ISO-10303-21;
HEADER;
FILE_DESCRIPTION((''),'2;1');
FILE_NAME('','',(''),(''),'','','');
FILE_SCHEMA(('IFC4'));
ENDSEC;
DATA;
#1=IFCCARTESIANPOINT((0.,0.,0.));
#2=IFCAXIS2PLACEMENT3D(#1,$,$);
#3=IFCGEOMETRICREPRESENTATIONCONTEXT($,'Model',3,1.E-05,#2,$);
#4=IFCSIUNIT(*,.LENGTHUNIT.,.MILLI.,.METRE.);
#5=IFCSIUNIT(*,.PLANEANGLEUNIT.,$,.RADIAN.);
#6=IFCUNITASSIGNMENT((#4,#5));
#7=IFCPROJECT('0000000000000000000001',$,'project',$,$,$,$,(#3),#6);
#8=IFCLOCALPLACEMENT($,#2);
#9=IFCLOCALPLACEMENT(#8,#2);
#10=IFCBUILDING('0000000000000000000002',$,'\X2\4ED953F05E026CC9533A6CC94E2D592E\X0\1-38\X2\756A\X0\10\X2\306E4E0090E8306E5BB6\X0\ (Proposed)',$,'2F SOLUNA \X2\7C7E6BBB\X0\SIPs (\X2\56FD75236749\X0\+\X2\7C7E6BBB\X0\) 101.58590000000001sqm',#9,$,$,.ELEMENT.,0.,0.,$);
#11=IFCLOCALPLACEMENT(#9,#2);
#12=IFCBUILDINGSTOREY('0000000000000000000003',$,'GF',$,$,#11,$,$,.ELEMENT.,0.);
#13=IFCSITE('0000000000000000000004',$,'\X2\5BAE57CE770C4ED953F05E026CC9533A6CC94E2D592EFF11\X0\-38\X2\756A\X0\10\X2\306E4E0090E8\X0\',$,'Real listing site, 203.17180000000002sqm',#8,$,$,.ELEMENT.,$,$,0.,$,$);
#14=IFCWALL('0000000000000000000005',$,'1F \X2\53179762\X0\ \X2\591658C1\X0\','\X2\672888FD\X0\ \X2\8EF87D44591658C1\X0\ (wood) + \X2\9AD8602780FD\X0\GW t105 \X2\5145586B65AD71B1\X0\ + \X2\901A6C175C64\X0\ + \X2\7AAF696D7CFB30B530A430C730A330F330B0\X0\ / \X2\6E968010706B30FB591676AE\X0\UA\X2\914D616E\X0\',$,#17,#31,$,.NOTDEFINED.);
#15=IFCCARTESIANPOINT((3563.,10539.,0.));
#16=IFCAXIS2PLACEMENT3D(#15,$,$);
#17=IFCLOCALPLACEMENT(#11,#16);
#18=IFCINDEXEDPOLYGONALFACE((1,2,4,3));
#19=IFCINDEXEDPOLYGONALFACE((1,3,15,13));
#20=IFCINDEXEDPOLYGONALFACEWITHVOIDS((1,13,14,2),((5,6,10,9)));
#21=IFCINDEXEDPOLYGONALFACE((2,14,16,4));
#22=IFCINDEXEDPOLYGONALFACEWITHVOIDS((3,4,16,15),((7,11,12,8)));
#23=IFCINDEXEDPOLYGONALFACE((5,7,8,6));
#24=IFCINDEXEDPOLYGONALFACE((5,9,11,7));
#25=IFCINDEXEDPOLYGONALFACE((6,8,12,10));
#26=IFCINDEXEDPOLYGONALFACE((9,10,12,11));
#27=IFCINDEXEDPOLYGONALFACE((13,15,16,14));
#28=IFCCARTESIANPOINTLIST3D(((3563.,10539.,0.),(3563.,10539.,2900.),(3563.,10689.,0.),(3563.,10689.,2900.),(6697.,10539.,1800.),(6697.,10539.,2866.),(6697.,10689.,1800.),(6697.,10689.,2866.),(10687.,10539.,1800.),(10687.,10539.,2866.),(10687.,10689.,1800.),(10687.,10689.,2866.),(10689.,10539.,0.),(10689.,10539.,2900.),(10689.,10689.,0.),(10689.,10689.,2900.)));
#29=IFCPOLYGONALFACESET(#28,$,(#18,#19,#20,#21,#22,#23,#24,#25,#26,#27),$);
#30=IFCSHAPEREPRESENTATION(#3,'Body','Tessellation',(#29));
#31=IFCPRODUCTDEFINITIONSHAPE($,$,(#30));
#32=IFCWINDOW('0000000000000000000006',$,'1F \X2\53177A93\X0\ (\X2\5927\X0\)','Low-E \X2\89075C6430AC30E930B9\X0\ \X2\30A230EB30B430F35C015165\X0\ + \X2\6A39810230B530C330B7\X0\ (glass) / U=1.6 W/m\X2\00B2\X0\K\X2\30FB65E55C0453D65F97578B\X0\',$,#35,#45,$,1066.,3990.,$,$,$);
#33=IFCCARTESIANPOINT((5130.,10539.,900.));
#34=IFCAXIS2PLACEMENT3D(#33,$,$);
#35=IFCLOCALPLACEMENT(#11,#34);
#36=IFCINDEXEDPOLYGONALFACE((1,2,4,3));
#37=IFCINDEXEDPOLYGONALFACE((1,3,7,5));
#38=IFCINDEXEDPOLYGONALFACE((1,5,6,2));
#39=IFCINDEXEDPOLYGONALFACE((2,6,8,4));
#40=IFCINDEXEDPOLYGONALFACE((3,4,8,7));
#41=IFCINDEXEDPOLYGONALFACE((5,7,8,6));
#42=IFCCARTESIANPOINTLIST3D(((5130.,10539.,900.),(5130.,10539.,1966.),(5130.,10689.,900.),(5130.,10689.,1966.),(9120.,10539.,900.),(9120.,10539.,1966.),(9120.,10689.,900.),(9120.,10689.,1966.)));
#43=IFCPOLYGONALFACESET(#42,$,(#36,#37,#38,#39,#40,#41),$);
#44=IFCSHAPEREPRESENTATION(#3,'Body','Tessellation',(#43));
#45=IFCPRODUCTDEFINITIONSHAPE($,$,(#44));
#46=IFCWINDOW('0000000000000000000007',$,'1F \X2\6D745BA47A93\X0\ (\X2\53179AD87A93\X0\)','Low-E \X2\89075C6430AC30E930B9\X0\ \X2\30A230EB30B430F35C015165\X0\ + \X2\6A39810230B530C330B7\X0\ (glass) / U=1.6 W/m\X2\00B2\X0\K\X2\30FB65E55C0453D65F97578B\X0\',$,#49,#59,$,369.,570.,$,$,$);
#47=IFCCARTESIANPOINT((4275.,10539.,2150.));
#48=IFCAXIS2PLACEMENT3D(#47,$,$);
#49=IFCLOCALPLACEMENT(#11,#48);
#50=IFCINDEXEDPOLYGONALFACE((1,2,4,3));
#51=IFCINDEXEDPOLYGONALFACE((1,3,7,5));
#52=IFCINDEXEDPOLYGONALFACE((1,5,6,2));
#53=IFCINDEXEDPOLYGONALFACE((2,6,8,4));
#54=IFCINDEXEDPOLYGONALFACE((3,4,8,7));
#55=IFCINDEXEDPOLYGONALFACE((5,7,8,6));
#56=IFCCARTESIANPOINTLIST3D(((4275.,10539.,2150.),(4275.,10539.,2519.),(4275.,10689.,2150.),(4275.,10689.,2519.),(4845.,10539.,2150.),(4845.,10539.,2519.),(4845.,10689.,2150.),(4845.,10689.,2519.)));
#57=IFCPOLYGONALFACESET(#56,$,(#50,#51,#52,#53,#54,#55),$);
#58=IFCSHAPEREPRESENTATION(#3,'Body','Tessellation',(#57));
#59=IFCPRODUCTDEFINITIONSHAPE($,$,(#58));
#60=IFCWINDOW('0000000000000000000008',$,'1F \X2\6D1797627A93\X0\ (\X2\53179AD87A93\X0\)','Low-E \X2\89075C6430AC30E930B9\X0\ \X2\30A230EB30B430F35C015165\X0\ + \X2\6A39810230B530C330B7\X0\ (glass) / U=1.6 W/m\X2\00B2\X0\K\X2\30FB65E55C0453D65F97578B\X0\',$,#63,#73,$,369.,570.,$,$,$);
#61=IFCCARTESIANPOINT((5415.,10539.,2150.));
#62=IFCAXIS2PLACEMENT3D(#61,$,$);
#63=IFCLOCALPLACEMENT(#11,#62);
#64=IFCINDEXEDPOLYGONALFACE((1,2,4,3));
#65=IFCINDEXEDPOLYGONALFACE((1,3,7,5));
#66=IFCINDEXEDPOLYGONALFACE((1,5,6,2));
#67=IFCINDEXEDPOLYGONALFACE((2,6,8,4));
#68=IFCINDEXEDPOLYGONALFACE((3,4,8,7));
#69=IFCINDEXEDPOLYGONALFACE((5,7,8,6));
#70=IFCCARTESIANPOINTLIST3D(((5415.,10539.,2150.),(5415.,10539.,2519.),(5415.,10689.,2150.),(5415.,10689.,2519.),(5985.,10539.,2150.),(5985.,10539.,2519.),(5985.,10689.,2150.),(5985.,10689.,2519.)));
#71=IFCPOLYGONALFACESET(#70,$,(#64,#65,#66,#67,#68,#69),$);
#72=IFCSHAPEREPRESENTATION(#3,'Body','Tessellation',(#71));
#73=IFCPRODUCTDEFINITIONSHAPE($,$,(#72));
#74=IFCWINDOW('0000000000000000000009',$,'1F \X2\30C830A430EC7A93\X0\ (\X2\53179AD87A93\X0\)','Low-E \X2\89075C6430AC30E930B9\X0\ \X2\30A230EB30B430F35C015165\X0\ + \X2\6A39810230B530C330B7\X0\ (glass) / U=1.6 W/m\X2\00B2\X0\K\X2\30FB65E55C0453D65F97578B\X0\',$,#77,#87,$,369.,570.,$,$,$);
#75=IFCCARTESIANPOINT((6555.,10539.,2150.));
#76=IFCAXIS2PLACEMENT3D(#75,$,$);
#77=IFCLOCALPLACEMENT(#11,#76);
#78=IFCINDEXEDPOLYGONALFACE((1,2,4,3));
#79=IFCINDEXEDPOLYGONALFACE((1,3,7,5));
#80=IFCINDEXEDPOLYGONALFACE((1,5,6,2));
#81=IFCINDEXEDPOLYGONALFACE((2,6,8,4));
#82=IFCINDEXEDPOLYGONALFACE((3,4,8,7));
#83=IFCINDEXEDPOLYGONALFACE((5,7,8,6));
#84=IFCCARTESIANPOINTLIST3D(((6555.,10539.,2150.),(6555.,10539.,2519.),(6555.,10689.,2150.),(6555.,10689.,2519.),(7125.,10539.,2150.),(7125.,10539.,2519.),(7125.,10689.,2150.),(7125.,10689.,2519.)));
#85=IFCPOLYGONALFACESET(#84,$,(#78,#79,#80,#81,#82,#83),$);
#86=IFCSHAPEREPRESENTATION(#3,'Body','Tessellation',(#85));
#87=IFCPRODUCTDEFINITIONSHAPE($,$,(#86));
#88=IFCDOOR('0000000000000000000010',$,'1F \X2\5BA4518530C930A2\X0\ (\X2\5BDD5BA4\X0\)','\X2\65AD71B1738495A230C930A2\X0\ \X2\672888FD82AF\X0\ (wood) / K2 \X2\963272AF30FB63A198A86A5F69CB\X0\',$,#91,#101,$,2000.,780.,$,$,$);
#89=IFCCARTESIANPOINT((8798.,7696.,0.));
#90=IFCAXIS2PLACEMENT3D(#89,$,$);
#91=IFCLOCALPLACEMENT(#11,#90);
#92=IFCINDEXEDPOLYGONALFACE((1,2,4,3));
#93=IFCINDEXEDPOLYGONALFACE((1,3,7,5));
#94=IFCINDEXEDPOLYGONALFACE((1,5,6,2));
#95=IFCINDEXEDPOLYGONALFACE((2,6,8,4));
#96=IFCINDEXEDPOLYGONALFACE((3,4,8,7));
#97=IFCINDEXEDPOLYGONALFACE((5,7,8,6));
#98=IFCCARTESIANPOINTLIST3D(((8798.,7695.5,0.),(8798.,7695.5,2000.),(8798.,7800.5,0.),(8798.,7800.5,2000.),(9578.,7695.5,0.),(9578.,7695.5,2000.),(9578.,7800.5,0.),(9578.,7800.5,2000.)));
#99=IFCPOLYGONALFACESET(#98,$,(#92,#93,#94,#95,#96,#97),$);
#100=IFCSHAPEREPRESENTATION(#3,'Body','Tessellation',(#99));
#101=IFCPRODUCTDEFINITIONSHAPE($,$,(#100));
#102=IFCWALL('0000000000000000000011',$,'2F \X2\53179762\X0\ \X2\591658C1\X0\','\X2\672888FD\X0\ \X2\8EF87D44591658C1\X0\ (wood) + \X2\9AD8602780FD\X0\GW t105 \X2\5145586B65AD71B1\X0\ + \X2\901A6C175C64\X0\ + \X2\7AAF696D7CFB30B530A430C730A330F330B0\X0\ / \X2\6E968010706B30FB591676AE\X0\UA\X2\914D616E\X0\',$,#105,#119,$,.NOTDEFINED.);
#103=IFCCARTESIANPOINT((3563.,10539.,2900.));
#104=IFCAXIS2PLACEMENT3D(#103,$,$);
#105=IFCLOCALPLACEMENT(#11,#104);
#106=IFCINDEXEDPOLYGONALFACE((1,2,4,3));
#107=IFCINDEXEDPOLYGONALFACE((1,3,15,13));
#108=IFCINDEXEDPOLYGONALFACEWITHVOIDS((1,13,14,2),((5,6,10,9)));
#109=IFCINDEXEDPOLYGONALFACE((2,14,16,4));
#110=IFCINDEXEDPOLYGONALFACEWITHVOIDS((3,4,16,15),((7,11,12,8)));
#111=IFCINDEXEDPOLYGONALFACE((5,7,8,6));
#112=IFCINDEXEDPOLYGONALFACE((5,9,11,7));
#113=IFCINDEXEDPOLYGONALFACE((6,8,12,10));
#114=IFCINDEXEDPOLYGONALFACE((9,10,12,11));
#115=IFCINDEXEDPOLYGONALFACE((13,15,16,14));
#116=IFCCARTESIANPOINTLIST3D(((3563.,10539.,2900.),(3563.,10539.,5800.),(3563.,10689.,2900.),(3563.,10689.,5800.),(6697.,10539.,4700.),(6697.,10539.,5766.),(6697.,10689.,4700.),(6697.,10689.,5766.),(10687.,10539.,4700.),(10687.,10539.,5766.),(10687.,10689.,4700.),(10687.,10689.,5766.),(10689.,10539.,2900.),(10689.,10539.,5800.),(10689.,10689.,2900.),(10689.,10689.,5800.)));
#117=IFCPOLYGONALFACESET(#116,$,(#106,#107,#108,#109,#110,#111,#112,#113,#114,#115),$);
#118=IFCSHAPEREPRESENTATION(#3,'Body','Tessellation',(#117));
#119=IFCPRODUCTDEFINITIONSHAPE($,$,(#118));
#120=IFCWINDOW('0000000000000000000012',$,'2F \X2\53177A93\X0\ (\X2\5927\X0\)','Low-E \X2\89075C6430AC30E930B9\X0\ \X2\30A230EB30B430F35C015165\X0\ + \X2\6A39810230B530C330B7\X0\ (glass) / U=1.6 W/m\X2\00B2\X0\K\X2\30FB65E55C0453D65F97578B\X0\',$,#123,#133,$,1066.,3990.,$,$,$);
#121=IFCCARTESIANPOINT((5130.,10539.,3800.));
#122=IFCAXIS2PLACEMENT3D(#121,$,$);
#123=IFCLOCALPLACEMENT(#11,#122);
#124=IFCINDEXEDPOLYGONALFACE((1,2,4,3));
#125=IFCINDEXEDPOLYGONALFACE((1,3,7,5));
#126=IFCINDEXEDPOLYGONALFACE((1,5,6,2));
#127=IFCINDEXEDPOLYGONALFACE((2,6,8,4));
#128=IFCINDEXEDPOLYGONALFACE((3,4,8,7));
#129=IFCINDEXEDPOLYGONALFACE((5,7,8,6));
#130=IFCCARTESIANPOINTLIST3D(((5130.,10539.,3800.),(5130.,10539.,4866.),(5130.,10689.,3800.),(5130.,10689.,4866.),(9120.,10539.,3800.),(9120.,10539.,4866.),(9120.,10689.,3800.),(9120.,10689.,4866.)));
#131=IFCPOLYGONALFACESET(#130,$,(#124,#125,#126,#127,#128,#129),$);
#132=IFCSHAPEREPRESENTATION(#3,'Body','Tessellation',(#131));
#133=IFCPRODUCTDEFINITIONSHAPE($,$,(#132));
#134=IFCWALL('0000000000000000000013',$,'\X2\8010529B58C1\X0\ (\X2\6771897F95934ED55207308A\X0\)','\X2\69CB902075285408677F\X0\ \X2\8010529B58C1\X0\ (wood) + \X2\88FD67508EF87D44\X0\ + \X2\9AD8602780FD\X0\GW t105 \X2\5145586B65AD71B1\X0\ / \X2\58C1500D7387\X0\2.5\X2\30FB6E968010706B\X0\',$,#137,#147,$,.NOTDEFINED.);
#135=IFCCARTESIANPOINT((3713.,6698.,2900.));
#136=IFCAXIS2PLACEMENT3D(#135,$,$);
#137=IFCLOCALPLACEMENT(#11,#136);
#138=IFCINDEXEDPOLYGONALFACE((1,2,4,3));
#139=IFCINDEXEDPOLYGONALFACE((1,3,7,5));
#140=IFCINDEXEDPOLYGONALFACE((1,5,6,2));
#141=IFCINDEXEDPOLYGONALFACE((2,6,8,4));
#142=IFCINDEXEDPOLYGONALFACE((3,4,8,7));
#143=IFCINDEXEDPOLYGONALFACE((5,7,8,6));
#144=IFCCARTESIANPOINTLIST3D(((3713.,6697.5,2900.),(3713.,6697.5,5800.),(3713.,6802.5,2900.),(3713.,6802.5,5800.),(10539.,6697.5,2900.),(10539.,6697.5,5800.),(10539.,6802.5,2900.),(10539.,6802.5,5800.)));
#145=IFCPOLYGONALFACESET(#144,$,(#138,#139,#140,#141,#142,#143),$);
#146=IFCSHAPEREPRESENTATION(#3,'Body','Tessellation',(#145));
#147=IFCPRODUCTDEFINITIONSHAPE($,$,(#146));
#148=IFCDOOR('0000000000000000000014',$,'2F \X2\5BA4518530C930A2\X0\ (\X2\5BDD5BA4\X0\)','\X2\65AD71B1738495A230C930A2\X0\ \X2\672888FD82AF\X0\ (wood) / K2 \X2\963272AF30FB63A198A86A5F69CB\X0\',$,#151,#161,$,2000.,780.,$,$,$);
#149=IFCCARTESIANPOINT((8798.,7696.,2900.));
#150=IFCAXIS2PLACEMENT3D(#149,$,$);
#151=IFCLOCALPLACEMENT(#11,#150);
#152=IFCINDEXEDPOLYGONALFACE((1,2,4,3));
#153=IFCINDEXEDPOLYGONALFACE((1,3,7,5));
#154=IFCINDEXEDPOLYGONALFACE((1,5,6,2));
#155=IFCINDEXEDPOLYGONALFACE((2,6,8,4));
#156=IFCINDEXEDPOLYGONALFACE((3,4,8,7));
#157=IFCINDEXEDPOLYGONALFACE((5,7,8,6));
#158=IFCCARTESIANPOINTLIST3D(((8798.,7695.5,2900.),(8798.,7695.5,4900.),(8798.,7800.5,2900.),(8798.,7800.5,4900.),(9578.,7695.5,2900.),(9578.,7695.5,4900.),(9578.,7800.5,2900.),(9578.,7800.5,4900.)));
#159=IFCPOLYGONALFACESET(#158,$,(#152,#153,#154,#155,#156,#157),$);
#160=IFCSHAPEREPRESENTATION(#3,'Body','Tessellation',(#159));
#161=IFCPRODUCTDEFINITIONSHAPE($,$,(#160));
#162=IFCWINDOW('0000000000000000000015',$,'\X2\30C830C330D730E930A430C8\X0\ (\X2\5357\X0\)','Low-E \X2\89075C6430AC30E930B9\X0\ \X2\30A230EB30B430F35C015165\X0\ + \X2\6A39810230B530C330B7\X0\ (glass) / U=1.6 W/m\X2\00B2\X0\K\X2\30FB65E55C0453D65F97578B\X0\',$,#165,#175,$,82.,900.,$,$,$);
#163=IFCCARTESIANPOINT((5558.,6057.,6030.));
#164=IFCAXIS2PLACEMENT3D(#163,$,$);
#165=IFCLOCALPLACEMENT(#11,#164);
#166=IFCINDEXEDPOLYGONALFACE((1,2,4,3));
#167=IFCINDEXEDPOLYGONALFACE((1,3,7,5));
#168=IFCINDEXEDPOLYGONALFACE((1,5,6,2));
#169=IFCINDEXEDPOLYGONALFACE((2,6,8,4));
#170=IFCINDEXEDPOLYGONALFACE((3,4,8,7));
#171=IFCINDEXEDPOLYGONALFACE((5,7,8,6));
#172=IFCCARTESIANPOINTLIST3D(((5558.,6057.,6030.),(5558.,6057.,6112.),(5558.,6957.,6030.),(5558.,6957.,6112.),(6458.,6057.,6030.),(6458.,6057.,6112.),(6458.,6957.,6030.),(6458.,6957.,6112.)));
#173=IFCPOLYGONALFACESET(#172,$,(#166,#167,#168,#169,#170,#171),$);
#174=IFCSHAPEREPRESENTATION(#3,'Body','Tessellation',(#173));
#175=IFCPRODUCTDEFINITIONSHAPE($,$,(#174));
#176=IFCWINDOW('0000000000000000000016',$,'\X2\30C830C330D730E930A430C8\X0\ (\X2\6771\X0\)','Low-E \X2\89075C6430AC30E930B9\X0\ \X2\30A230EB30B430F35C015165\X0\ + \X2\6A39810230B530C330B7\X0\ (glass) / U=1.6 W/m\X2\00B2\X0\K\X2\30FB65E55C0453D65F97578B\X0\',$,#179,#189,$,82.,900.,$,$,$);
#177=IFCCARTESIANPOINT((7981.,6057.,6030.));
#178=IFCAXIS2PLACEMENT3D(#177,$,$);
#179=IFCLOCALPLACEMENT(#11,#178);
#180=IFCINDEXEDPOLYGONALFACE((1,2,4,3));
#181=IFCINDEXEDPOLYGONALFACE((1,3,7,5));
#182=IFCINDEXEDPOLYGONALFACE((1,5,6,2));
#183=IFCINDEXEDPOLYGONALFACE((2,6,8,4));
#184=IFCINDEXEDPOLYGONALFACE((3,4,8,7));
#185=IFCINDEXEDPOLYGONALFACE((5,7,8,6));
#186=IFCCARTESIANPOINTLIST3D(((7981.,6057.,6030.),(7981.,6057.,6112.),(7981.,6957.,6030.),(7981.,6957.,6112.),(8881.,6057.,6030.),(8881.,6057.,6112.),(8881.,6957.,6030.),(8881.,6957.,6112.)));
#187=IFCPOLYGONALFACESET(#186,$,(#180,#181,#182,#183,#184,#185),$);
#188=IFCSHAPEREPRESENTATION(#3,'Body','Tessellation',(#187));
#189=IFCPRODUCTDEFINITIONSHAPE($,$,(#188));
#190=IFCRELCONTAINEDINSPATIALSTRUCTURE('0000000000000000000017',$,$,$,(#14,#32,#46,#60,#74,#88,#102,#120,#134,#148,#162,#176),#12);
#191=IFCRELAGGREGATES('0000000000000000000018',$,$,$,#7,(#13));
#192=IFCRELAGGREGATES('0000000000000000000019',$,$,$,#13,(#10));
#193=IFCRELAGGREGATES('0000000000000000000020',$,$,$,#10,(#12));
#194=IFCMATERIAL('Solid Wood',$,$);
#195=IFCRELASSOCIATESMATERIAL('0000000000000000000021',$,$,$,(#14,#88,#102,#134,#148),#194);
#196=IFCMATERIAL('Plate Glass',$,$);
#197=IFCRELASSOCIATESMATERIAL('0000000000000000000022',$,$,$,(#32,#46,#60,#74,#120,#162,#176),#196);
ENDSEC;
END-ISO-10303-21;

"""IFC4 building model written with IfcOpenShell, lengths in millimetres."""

from ifc_helpers import new_model, si_unit, frame, frame_2d, origin, place, context, project, spatial, rectangle, extrude, material, element, fill, save


model = new_model("IFC4")

# Units and contexts
model_context = context("Model", 3, precision=1e-05, world=origin())
ifc_project = project(units=[si_unit("LENGTHUNIT", "METRE", prefix="MILLI"), si_unit("PLANEANGLEUNIT", "RADIAN")], contexts=[model_context])

# Site, building, storey
site_placement = place(None, origin())
site = spatial("IfcSite", under=ifc_project, at=site_placement, Name="宮城県仙台市泉区泉中央１-38番10の一部", ObjectType="Real listing site, 203.17180000000002sqm", CompositionType="ELEMENT", RefElevation=0.0)
building_placement = place(site_placement, origin())
building = spatial("IfcBuilding", under=site, at=building_placement, Name="仙台市泉区泉中央1-38番10の一部の家 (Proposed)", ObjectType="2F SOLUNA 籾殻SIPs (国産杉+籾殻) 101.58590000000001sqm", CompositionType="ELEMENT", ElevationOfRefHeight=0.0, ElevationOfTerrain=0.0)
storey_placement = place(building_placement, origin())
storey = spatial("IfcBuildingStorey", under=building, at=storey_placement, Name="GF", CompositionType="ELEMENT", Elevation=0.0)

# Wall, openings, windows
ifc_material_1 = material(Name="Solid Wood")
wall_1_placement = place(storey_placement, frame((3563.0, 10539.0, 0.0)))
wall_1 = element("IfcWall", 1, at=wall_1_placement, inside=storey, material=ifc_material_1, Name="1F 北面 外壁", Description="木製 軸組外壁 (wood) + 高性能GW t105 充填断熱 + 通気層 + 窯業系サイディング / 準耐火・外皮UA配慮", PredefinedType="NOTDEFINED", context=model_context, shape_type="SweptSolid", body=[
    extrude(rectangle(XDim=7126.0, YDim=150.0, at=frame_2d((3563.0, 75.0))), frame((3563.0, 10539.0, 0.0)), (0.0, 0.0, 1.0), 2900.0),
])
opening_1_placement = place(storey_placement, frame((5130.0, 10539.0, 900.0)))
opening_1 = element("IfcOpeningElement", 2, at=opening_1_placement, cuts=wall_1, PredefinedType="NOTDEFINED", context=model_context, shape_type="SweptSolid", body=[
    extrude(rectangle(XDim=3990.0, YDim=150.0, at=frame_2d((1995.0, 75.0))), frame((5130.0, 10539.0, 900.0)), (0.0, 0.0, 1.0), 1066.0),
])
opening_2_placement = place(storey_placement, frame((4275.0, 10539.0, 2150.0)))
opening_2 = element("IfcOpeningElement", 3, at=opening_2_placement, cuts=wall_1, PredefinedType="NOTDEFINED", context=model_context, shape_type="SweptSolid", body=[
    extrude(rectangle(XDim=570.0, YDim=150.0, at=frame_2d((285.0, 75.0))), frame((4275.0, 10539.0, 2150.0)), (0.0, 0.0, 1.0), 369.0),
])
opening_3_placement = place(storey_placement, frame((5415.0, 10539.0, 2150.0)))
opening_3 = element("IfcOpeningElement", 4, at=opening_3_placement, cuts=wall_1, PredefinedType="NOTDEFINED", context=model_context, shape_type="SweptSolid", body=[
    extrude(rectangle(XDim=570.0, YDim=150.0, at=frame_2d((285.0, 75.0))), frame((5415.0, 10539.0, 2150.0)), (0.0, 0.0, 1.0), 369.0),
])
opening_4_placement = place(storey_placement, frame((6555.0, 10539.0, 2150.0)))
opening_4 = element("IfcOpeningElement", 5, at=opening_4_placement, cuts=wall_1, PredefinedType="NOTDEFINED", context=model_context, shape_type="SweptSolid", body=[
    extrude(rectangle(XDim=570.0, YDim=150.0, at=frame_2d((285.0, 75.0))), frame((6555.0, 10539.0, 2150.0)), (0.0, 0.0, 1.0), 369.0),
])
ifc_material_2 = material(Name="Plate Glass")
window_1_placement = place(storey_placement, frame((5130.0, 10539.0, 900.0)))
window_1 = element("IfcWindow", 6, at=window_1_placement, inside=storey, material=ifc_material_2, Name="1F 北窓 (大)", Description="Low-E 複層ガラス アルゴン封入 + 樹脂サッシ (glass) / U=1.6 W/m²K・日射取得型", OverallHeight=1066.0, OverallWidth=3990.0, context=model_context, shape_type="SweptSolid", body=[
    extrude(rectangle(XDim=3990.0, YDim=150.0, at=frame_2d((1995.0, 75.0))), frame((5130.0, 10539.0, 900.0)), (0.0, 0.0, 1.0), 1066.0),
])
fill(opening_1, window_1)
window_2_placement = place(storey_placement, frame((4275.0, 10539.0, 2150.0)))
window_2 = element("IfcWindow", 7, at=window_2_placement, inside=storey, material=ifc_material_2, Name="1F 浴室窓 (北高窓)", Description="Low-E 複層ガラス アルゴン封入 + 樹脂サッシ (glass) / U=1.6 W/m²K・日射取得型", OverallHeight=369.0, OverallWidth=570.0, context=model_context, shape_type="SweptSolid", body=[
    extrude(rectangle(XDim=570.0, YDim=150.0, at=frame_2d((285.0, 75.0))), frame((4275.0, 10539.0, 2150.0)), (0.0, 0.0, 1.0), 369.0),
])
fill(opening_2, window_2)
window_3_placement = place(storey_placement, frame((5415.0, 10539.0, 2150.0)))
window_3 = element("IfcWindow", 8, at=window_3_placement, inside=storey, material=ifc_material_2, Name="1F 洗面窓 (北高窓)", Description="Low-E 複層ガラス アルゴン封入 + 樹脂サッシ (glass) / U=1.6 W/m²K・日射取得型", OverallHeight=369.0, OverallWidth=570.0, context=model_context, shape_type="SweptSolid", body=[
    extrude(rectangle(XDim=570.0, YDim=150.0, at=frame_2d((285.0, 75.0))), frame((5415.0, 10539.0, 2150.0)), (0.0, 0.0, 1.0), 369.0),
])
fill(opening_3, window_3)
window_4_placement = place(storey_placement, frame((6555.0, 10539.0, 2150.0)))
window_4 = element("IfcWindow", 9, at=window_4_placement, inside=storey, material=ifc_material_2, Name="1F トイレ窓 (北高窓)", Description="Low-E 複層ガラス アルゴン封入 + 樹脂サッシ (glass) / U=1.6 W/m²K・日射取得型", OverallHeight=369.0, OverallWidth=570.0, context=model_context, shape_type="SweptSolid", body=[
    extrude(rectangle(XDim=570.0, YDim=150.0, at=frame_2d((285.0, 75.0))), frame((6555.0, 10539.0, 2150.0)), (0.0, 0.0, 1.0), 369.0),
])
fill(opening_4, window_4)

# Door
door_1_placement = place(storey_placement, frame((8798.0, 7696.0, 0.0)))
element("IfcDoor", 10, at=door_1_placement, inside=storey, material=ifc_material_1, Name="1F 室内ドア (寝室)", Description="断熱玄関ドア 木製芯 (wood) / K2 防犯・採風機構", OverallHeight=2000.0, OverallWidth=780.0, context=model_context, shape_type="SweptSolid", body=[
    extrude(rectangle(XDim=780.0, YDim=105.0, at=frame_2d((390.0, 52.0))), frame((8798.0, 7696.0, 0.0)), (0.0, 0.0, 1.0), 2000.0),
])

# Wall, opening, window
wall_2_placement = place(storey_placement, frame((3563.0, 10539.0, 2900.0)))
wall_2 = element("IfcWall", 11, at=wall_2_placement, inside=storey, material=ifc_material_1, Name="2F 北面 外壁", Description="木製 軸組外壁 (wood) + 高性能GW t105 充填断熱 + 通気層 + 窯業系サイディング / 準耐火・外皮UA配慮", PredefinedType="NOTDEFINED", context=model_context, shape_type="SweptSolid", body=[
    extrude(rectangle(XDim=7126.0, YDim=150.0, at=frame_2d((3563.0, 75.0))), frame((3563.0, 10539.0, 2900.0)), (0.0, 0.0, 1.0), 2900.0),
])
opening_5_placement = place(storey_placement, frame((5130.0, 10539.0, 3800.0)))
opening_5 = element("IfcOpeningElement", 12, at=opening_5_placement, cuts=wall_2, PredefinedType="NOTDEFINED", context=model_context, shape_type="SweptSolid", body=[
    extrude(rectangle(XDim=3990.0, YDim=150.0, at=frame_2d((1995.0, 75.0))), frame((5130.0, 10539.0, 3800.0)), (0.0, 0.0, 1.0), 1066.0),
])
window_5_placement = place(storey_placement, frame((5130.0, 10539.0, 3800.0)))
window_5 = element("IfcWindow", 13, at=window_5_placement, inside=storey, material=ifc_material_2, Name="2F 北窓 (大)", Description="Low-E 複層ガラス アルゴン封入 + 樹脂サッシ (glass) / U=1.6 W/m²K・日射取得型", OverallHeight=1066.0, OverallWidth=3990.0, context=model_context, shape_type="SweptSolid", body=[
    extrude(rectangle(XDim=3990.0, YDim=150.0, at=frame_2d((1995.0, 75.0))), frame((5130.0, 10539.0, 3800.0)), (0.0, 0.0, 1.0), 1066.0),
])
fill(opening_5, window_5)

# Wall
wall_3_placement = place(storey_placement, frame((3713.0, 6698.0, 2900.0)))
element("IfcWall", 14, at=wall_3_placement, inside=storey, material=ifc_material_1, Name="耐力壁 (東西間仕切り)", Description="構造用合板 耐力壁 (wood) + 製材軸組 + 高性能GW t105 充填断熱 / 壁倍率2.5・準耐火", PredefinedType="NOTDEFINED", context=model_context, shape_type="SweptSolid", body=[
    extrude(rectangle(XDim=6826.0, YDim=105.0, at=frame_2d((3413.0, 52.0))), frame((3713.0, 6698.0, 2900.0)), (0.0, 0.0, 1.0), 2900.0),
])

# Door
door_2_placement = place(storey_placement, frame((8798.0, 7696.0, 2900.0)))
element("IfcDoor", 15, at=door_2_placement, inside=storey, material=ifc_material_1, Name="2F 室内ドア (寝室)", Description="断熱玄関ドア 木製芯 (wood) / K2 防犯・採風機構", OverallHeight=2000.0, OverallWidth=780.0, context=model_context, shape_type="SweptSolid", body=[
    extrude(rectangle(XDim=780.0, YDim=105.0, at=frame_2d((390.0, 52.0))), frame((8798.0, 7696.0, 2900.0)), (0.0, 0.0, 1.0), 2000.0),
])

# Windows
window_6_placement = place(storey_placement, frame((5558.0, 6057.0, 6030.0)))
element("IfcWindow", 16, at=window_6_placement, inside=storey, material=ifc_material_2, Name="トップライト (南)", Description="Low-E 複層ガラス アルゴン封入 + 樹脂サッシ (glass) / U=1.6 W/m²K・日射取得型", OverallHeight=82.0, OverallWidth=900.0, context=model_context, shape_type="SweptSolid", body=[
    extrude(rectangle(XDim=900.0, YDim=900.0, at=frame_2d((450.0, 450.0))), frame((5558.0, 6057.0, 6030.0)), (0.0, 0.0, 1.0), 82.0),
])
window_7_placement = place(storey_placement, frame((7981.0, 6057.0, 6030.0)))
element("IfcWindow", 17, at=window_7_placement, inside=storey, material=ifc_material_2, Name="トップライト (東)", Description="Low-E 複層ガラス アルゴン封入 + 樹脂サッシ (glass) / U=1.6 W/m²K・日射取得型", OverallHeight=82.0, OverallWidth=900.0, context=model_context, shape_type="SweptSolid", body=[
    extrude(rectangle(XDim=900.0, YDim=900.0, at=frame_2d((450.0, 450.0))), frame((7981.0, 6057.0, 6030.0)), (0.0, 0.0, 1.0), 82.0),
])

save(model, "model.ifc")
